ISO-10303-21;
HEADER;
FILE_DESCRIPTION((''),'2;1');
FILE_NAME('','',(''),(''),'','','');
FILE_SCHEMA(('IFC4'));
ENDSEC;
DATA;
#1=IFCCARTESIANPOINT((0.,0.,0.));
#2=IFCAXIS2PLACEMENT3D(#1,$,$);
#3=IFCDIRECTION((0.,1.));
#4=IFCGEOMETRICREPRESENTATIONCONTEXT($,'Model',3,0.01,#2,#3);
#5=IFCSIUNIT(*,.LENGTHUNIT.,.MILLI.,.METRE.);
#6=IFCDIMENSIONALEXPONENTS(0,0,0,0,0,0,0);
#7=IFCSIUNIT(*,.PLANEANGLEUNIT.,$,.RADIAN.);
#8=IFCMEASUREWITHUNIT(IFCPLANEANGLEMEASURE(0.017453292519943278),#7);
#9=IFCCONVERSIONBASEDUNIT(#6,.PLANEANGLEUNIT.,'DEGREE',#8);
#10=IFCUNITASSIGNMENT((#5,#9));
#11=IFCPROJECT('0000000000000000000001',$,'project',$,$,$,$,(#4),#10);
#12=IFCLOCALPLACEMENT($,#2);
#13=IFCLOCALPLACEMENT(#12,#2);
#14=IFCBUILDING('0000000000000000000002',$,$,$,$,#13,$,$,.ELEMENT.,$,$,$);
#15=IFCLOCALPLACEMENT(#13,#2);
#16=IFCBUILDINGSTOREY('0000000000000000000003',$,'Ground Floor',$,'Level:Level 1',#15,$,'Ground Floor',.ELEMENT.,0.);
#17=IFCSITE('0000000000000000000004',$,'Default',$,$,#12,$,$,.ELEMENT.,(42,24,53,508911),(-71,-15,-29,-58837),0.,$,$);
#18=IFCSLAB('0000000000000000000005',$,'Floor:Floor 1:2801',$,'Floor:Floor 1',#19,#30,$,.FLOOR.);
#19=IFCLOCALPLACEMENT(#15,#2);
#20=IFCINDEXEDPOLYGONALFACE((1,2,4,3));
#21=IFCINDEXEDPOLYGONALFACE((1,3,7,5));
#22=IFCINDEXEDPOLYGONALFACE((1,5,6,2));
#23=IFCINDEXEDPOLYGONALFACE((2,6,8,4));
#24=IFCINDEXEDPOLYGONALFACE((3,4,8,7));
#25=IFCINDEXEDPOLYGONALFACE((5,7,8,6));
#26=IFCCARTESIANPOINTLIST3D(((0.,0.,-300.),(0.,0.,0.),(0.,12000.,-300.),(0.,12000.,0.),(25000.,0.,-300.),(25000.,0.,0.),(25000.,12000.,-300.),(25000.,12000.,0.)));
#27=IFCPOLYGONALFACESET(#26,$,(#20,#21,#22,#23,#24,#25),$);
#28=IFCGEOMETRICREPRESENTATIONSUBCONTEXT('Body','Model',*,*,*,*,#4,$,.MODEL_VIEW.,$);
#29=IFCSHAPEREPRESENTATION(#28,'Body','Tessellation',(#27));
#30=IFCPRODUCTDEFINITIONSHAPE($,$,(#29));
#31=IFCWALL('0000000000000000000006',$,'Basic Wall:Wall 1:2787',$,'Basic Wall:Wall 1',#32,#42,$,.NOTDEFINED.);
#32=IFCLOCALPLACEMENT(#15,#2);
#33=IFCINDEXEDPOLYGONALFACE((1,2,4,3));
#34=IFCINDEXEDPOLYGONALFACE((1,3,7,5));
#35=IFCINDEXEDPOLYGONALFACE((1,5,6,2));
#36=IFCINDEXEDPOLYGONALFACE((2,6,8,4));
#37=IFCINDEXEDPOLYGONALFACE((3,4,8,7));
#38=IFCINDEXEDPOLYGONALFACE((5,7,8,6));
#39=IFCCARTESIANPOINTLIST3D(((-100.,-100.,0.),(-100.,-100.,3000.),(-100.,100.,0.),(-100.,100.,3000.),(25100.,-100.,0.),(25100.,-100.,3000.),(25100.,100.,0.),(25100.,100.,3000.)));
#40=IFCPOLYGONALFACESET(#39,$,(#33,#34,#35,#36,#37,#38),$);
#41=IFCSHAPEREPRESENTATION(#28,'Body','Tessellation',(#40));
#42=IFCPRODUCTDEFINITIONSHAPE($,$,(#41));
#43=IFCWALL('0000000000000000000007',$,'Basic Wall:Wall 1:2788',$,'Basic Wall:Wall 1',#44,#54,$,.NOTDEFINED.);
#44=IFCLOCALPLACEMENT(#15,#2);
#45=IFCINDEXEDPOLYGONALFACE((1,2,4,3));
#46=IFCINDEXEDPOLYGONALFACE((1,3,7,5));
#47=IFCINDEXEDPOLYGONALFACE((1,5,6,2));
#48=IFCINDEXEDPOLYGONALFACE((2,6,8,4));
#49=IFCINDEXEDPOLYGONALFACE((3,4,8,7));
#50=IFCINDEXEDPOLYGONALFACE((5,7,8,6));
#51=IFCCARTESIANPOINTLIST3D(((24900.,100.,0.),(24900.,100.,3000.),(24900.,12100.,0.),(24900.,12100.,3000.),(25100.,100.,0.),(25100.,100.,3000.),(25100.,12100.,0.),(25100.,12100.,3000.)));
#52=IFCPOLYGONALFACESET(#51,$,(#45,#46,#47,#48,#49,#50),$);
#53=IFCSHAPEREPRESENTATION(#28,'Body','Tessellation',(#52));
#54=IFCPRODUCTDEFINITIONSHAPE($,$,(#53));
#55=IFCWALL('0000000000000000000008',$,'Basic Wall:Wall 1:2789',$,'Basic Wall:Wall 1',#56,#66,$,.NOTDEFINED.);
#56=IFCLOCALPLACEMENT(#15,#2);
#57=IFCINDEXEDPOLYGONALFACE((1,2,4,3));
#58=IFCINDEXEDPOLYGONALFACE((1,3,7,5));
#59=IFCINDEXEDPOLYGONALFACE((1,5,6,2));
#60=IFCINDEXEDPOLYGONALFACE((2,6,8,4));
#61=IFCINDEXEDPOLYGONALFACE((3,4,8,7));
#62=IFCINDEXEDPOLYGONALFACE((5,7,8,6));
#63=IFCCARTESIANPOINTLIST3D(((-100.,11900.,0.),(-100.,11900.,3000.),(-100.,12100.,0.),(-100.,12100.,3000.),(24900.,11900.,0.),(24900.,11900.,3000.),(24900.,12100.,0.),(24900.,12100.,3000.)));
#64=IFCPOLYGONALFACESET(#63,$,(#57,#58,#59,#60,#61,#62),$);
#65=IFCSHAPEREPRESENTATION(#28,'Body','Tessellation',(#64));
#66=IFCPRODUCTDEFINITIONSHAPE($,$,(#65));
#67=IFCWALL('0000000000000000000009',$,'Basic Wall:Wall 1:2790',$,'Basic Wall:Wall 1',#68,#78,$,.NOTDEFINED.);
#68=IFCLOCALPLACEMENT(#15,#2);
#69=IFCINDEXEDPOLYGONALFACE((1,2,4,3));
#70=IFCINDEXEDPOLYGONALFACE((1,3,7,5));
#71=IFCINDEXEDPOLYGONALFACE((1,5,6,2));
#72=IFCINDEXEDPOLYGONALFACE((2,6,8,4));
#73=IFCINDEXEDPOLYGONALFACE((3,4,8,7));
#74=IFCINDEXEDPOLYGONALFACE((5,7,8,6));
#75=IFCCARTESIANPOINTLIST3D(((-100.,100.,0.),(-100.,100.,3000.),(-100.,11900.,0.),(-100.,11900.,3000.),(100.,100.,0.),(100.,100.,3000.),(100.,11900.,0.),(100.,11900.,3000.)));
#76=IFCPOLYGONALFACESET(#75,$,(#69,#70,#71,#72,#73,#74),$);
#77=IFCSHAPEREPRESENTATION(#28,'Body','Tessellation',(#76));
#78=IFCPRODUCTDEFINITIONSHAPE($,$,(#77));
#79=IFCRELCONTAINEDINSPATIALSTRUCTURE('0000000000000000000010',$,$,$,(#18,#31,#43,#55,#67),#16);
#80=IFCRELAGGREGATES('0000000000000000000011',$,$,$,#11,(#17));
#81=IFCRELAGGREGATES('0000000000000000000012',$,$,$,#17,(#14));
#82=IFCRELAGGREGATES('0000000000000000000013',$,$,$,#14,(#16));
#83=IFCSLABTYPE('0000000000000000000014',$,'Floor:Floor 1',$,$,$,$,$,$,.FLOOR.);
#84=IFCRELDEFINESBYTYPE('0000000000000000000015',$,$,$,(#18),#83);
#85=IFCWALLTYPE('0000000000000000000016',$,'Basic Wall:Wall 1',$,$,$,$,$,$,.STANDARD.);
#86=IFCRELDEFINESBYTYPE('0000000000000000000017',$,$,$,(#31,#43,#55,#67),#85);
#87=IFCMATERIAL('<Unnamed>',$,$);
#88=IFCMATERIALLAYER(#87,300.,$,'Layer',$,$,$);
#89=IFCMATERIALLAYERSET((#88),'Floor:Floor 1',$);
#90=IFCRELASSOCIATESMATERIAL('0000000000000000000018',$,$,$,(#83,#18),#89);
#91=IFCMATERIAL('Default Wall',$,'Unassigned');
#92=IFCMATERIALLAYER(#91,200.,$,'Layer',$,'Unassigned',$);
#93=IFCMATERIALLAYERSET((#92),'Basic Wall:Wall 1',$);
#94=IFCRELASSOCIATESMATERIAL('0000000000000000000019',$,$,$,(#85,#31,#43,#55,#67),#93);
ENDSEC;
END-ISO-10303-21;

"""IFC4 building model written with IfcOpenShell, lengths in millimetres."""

from ifc_helpers import new_model, entity, si_unit, converted_unit, direction, frame, frame_2d, origin, origin_2d_with_axis, place, context, subcontext, project, spatial, rectangle, extrude, material, layer, layer_set, layer_usage, type_object, element, save


model = new_model("IFC4")

# Units and contexts
model_context = context("Model", 3, precision=0.01, world=origin(), true_north=direction((0.0, 1.0)))
body_context = subcontext(model_context, "Body", "Model", "MODEL_VIEW")
ifc_project = project(units=[si_unit("LENGTHUNIT", "METRE", prefix="MILLI"), converted_unit("PLANEANGLEUNIT", "DEGREE", entity("IfcPlaneAngleMeasure", 0.017453292519943278), si_unit("PLANEANGLEUNIT", "RADIAN"), dimensions=[0, 0, 0, 0, 0, 0, 0])], contexts=[model_context])

# Site, building, storey
site_placement = place(None, origin())
site = spatial("IfcSite", under=ifc_project, at=site_placement, Name="Default", CompositionType="ELEMENT", RefLatitude=(42, 24, 53, 508911), RefLongitude=(-71, -15, -29, -58837), RefElevation=0.0)
building_placement = place(site_placement, origin())
building = spatial("IfcBuilding", under=site, at=building_placement, CompositionType="ELEMENT")
storey_placement = place(building_placement, origin())
storey = spatial("IfcBuildingStorey", under=building, at=storey_placement, Name="Ground Floor", ObjectType="Level:Level 1", LongName="Ground Floor", CompositionType="ELEMENT", Elevation=0.0)

# Shared definitions
ifc_material_1 = material(Name="Default Wall", Category="Unassigned")

# Slab
ifc_material_2 = material(Name="<Unnamed>")
ifc_layer_1 = layer(ifc_material_2, 300.0, Name="Layer")
ifc_layer_set_1 = layer_set([ifc_layer_1], Name="Floor:Floor 1")
ifc_layer_usage_1 = layer_usage(ifc_layer_set_1, "AXIS3", "POSITIVE", 0.0)
slab_type = type_object("IfcSlabType", Name="Floor:Floor 1", PredefinedType="FLOOR", material=ifc_layer_set_1)
slab_placement = place(storey_placement, origin())
element("IfcSlab", 1, at=slab_placement, inside=storey, type_object=slab_type, material=ifc_layer_usage_1, Name="Floor:Floor 1:2801", ObjectType="Floor:Floor 1", PredefinedType="FLOOR", context=body_context, shape_type="SweptSolid", body=[
    extrude(rectangle(XDim=12000.0, YDim=25000.0, at=origin_2d_with_axis()), frame((12500.0, 6000.0, 0.0), z_axis=(0.0, 0.0, -1.0), x_axis=(0.0, 1.0, 0.0)), (0.0, 0.0, 1.0), 300.0),
])

# Walls
ifc_layer_2 = layer(ifc_material_1, 200.0, Name="Layer", Category="Unassigned")
ifc_layer_set_2 = layer_set([ifc_layer_2], Name="Basic Wall:Wall 1")
ifc_layer_usage_2 = layer_usage(ifc_layer_set_2, "AXIS2", "NEGATIVE", 100.0)
wall_type = type_object("IfcWallType", Name="Basic Wall:Wall 1", PredefinedType="STANDARD", material=ifc_layer_set_2)
wall_1_placement = place(storey_placement, frame((-100.0, 0.0, 0.0)))
element("IfcWall", 2, at=wall_1_placement, inside=storey, type_object=wall_type, material=ifc_layer_usage_2, Name="Basic Wall:Wall 1:2787", ObjectType="Basic Wall:Wall 1", PredefinedType="NOTDEFINED", context=body_context, shape_type="SweptSolid", body=[
    extrude(rectangle(XDim=25200.0, YDim=200.0, at=frame_2d((12600.0, 0.0), x_axis=(-1.0, 0.0))), origin(), (0.0, 0.0, 1.0), 3000.0),
])
ifc_layer_usage_3 = layer_usage(ifc_layer_set_2, "AXIS2", "NEGATIVE", 100.0)
wall_2_placement = place(storey_placement, frame((25000.0, 100.0, 0.0), z_axis=(0.0, 0.0, 1.0), x_axis=(0.0, 1.0, 0.0)))
element("IfcWall", 3, at=wall_2_placement, inside=storey, type_object=wall_type, material=ifc_layer_usage_3, Name="Basic Wall:Wall 1:2788", ObjectType="Basic Wall:Wall 1", PredefinedType="NOTDEFINED", context=body_context, shape_type="SweptSolid", body=[
    extrude(rectangle(XDim=12000.0, YDim=200.0, at=frame_2d((6000.0, 0.0), x_axis=(-1.0, 0.0))), origin(), (0.0, 0.0, 1.0), 3000.0),
])
ifc_layer_usage_4 = layer_usage(ifc_layer_set_2, "AXIS2", "NEGATIVE", 100.0)
wall_3_placement = place(storey_placement, frame((24900.0, 12000.0, 0.0), z_axis=(0.0, 0.0, 1.0), x_axis=(-1.0, 0.0, 0.0)))
element("IfcWall", 4, at=wall_3_placement, inside=storey, type_object=wall_type, material=ifc_layer_usage_4, Name="Basic Wall:Wall 1:2789", ObjectType="Basic Wall:Wall 1", PredefinedType="NOTDEFINED", context=body_context, shape_type="SweptSolid", body=[
    extrude(rectangle(XDim=25000.0, YDim=200.0, at=frame_2d((12500.0, 0.0), x_axis=(-1.0, 0.0))), origin(), (0.0, 0.0, 1.0), 3000.0),
])
ifc_layer_usage_5 = layer_usage(ifc_layer_set_2, "AXIS2", "NEGATIVE", 100.0)
wall_4_placement = place(storey_placement, frame((0.0, 11900.0, 0.0), z_axis=(0.0, 0.0, 1.0), x_axis=(0.0, -1.0, 0.0)))
element("IfcWall", 5, at=wall_4_placement, inside=storey, type_object=wall_type, material=ifc_layer_usage_5, Name="Basic Wall:Wall 1:2790", ObjectType="Basic Wall:Wall 1", PredefinedType="NOTDEFINED", context=body_context, shape_type="SweptSolid", body=[
    extrude(rectangle(XDim=11800.0, YDim=200.0, at=frame_2d((5900.0, 0.0), x_axis=(-1.0, 0.0))), origin(), (0.0, 0.0, 1.0), 3000.0),
])

save(model, "model.ifc")
